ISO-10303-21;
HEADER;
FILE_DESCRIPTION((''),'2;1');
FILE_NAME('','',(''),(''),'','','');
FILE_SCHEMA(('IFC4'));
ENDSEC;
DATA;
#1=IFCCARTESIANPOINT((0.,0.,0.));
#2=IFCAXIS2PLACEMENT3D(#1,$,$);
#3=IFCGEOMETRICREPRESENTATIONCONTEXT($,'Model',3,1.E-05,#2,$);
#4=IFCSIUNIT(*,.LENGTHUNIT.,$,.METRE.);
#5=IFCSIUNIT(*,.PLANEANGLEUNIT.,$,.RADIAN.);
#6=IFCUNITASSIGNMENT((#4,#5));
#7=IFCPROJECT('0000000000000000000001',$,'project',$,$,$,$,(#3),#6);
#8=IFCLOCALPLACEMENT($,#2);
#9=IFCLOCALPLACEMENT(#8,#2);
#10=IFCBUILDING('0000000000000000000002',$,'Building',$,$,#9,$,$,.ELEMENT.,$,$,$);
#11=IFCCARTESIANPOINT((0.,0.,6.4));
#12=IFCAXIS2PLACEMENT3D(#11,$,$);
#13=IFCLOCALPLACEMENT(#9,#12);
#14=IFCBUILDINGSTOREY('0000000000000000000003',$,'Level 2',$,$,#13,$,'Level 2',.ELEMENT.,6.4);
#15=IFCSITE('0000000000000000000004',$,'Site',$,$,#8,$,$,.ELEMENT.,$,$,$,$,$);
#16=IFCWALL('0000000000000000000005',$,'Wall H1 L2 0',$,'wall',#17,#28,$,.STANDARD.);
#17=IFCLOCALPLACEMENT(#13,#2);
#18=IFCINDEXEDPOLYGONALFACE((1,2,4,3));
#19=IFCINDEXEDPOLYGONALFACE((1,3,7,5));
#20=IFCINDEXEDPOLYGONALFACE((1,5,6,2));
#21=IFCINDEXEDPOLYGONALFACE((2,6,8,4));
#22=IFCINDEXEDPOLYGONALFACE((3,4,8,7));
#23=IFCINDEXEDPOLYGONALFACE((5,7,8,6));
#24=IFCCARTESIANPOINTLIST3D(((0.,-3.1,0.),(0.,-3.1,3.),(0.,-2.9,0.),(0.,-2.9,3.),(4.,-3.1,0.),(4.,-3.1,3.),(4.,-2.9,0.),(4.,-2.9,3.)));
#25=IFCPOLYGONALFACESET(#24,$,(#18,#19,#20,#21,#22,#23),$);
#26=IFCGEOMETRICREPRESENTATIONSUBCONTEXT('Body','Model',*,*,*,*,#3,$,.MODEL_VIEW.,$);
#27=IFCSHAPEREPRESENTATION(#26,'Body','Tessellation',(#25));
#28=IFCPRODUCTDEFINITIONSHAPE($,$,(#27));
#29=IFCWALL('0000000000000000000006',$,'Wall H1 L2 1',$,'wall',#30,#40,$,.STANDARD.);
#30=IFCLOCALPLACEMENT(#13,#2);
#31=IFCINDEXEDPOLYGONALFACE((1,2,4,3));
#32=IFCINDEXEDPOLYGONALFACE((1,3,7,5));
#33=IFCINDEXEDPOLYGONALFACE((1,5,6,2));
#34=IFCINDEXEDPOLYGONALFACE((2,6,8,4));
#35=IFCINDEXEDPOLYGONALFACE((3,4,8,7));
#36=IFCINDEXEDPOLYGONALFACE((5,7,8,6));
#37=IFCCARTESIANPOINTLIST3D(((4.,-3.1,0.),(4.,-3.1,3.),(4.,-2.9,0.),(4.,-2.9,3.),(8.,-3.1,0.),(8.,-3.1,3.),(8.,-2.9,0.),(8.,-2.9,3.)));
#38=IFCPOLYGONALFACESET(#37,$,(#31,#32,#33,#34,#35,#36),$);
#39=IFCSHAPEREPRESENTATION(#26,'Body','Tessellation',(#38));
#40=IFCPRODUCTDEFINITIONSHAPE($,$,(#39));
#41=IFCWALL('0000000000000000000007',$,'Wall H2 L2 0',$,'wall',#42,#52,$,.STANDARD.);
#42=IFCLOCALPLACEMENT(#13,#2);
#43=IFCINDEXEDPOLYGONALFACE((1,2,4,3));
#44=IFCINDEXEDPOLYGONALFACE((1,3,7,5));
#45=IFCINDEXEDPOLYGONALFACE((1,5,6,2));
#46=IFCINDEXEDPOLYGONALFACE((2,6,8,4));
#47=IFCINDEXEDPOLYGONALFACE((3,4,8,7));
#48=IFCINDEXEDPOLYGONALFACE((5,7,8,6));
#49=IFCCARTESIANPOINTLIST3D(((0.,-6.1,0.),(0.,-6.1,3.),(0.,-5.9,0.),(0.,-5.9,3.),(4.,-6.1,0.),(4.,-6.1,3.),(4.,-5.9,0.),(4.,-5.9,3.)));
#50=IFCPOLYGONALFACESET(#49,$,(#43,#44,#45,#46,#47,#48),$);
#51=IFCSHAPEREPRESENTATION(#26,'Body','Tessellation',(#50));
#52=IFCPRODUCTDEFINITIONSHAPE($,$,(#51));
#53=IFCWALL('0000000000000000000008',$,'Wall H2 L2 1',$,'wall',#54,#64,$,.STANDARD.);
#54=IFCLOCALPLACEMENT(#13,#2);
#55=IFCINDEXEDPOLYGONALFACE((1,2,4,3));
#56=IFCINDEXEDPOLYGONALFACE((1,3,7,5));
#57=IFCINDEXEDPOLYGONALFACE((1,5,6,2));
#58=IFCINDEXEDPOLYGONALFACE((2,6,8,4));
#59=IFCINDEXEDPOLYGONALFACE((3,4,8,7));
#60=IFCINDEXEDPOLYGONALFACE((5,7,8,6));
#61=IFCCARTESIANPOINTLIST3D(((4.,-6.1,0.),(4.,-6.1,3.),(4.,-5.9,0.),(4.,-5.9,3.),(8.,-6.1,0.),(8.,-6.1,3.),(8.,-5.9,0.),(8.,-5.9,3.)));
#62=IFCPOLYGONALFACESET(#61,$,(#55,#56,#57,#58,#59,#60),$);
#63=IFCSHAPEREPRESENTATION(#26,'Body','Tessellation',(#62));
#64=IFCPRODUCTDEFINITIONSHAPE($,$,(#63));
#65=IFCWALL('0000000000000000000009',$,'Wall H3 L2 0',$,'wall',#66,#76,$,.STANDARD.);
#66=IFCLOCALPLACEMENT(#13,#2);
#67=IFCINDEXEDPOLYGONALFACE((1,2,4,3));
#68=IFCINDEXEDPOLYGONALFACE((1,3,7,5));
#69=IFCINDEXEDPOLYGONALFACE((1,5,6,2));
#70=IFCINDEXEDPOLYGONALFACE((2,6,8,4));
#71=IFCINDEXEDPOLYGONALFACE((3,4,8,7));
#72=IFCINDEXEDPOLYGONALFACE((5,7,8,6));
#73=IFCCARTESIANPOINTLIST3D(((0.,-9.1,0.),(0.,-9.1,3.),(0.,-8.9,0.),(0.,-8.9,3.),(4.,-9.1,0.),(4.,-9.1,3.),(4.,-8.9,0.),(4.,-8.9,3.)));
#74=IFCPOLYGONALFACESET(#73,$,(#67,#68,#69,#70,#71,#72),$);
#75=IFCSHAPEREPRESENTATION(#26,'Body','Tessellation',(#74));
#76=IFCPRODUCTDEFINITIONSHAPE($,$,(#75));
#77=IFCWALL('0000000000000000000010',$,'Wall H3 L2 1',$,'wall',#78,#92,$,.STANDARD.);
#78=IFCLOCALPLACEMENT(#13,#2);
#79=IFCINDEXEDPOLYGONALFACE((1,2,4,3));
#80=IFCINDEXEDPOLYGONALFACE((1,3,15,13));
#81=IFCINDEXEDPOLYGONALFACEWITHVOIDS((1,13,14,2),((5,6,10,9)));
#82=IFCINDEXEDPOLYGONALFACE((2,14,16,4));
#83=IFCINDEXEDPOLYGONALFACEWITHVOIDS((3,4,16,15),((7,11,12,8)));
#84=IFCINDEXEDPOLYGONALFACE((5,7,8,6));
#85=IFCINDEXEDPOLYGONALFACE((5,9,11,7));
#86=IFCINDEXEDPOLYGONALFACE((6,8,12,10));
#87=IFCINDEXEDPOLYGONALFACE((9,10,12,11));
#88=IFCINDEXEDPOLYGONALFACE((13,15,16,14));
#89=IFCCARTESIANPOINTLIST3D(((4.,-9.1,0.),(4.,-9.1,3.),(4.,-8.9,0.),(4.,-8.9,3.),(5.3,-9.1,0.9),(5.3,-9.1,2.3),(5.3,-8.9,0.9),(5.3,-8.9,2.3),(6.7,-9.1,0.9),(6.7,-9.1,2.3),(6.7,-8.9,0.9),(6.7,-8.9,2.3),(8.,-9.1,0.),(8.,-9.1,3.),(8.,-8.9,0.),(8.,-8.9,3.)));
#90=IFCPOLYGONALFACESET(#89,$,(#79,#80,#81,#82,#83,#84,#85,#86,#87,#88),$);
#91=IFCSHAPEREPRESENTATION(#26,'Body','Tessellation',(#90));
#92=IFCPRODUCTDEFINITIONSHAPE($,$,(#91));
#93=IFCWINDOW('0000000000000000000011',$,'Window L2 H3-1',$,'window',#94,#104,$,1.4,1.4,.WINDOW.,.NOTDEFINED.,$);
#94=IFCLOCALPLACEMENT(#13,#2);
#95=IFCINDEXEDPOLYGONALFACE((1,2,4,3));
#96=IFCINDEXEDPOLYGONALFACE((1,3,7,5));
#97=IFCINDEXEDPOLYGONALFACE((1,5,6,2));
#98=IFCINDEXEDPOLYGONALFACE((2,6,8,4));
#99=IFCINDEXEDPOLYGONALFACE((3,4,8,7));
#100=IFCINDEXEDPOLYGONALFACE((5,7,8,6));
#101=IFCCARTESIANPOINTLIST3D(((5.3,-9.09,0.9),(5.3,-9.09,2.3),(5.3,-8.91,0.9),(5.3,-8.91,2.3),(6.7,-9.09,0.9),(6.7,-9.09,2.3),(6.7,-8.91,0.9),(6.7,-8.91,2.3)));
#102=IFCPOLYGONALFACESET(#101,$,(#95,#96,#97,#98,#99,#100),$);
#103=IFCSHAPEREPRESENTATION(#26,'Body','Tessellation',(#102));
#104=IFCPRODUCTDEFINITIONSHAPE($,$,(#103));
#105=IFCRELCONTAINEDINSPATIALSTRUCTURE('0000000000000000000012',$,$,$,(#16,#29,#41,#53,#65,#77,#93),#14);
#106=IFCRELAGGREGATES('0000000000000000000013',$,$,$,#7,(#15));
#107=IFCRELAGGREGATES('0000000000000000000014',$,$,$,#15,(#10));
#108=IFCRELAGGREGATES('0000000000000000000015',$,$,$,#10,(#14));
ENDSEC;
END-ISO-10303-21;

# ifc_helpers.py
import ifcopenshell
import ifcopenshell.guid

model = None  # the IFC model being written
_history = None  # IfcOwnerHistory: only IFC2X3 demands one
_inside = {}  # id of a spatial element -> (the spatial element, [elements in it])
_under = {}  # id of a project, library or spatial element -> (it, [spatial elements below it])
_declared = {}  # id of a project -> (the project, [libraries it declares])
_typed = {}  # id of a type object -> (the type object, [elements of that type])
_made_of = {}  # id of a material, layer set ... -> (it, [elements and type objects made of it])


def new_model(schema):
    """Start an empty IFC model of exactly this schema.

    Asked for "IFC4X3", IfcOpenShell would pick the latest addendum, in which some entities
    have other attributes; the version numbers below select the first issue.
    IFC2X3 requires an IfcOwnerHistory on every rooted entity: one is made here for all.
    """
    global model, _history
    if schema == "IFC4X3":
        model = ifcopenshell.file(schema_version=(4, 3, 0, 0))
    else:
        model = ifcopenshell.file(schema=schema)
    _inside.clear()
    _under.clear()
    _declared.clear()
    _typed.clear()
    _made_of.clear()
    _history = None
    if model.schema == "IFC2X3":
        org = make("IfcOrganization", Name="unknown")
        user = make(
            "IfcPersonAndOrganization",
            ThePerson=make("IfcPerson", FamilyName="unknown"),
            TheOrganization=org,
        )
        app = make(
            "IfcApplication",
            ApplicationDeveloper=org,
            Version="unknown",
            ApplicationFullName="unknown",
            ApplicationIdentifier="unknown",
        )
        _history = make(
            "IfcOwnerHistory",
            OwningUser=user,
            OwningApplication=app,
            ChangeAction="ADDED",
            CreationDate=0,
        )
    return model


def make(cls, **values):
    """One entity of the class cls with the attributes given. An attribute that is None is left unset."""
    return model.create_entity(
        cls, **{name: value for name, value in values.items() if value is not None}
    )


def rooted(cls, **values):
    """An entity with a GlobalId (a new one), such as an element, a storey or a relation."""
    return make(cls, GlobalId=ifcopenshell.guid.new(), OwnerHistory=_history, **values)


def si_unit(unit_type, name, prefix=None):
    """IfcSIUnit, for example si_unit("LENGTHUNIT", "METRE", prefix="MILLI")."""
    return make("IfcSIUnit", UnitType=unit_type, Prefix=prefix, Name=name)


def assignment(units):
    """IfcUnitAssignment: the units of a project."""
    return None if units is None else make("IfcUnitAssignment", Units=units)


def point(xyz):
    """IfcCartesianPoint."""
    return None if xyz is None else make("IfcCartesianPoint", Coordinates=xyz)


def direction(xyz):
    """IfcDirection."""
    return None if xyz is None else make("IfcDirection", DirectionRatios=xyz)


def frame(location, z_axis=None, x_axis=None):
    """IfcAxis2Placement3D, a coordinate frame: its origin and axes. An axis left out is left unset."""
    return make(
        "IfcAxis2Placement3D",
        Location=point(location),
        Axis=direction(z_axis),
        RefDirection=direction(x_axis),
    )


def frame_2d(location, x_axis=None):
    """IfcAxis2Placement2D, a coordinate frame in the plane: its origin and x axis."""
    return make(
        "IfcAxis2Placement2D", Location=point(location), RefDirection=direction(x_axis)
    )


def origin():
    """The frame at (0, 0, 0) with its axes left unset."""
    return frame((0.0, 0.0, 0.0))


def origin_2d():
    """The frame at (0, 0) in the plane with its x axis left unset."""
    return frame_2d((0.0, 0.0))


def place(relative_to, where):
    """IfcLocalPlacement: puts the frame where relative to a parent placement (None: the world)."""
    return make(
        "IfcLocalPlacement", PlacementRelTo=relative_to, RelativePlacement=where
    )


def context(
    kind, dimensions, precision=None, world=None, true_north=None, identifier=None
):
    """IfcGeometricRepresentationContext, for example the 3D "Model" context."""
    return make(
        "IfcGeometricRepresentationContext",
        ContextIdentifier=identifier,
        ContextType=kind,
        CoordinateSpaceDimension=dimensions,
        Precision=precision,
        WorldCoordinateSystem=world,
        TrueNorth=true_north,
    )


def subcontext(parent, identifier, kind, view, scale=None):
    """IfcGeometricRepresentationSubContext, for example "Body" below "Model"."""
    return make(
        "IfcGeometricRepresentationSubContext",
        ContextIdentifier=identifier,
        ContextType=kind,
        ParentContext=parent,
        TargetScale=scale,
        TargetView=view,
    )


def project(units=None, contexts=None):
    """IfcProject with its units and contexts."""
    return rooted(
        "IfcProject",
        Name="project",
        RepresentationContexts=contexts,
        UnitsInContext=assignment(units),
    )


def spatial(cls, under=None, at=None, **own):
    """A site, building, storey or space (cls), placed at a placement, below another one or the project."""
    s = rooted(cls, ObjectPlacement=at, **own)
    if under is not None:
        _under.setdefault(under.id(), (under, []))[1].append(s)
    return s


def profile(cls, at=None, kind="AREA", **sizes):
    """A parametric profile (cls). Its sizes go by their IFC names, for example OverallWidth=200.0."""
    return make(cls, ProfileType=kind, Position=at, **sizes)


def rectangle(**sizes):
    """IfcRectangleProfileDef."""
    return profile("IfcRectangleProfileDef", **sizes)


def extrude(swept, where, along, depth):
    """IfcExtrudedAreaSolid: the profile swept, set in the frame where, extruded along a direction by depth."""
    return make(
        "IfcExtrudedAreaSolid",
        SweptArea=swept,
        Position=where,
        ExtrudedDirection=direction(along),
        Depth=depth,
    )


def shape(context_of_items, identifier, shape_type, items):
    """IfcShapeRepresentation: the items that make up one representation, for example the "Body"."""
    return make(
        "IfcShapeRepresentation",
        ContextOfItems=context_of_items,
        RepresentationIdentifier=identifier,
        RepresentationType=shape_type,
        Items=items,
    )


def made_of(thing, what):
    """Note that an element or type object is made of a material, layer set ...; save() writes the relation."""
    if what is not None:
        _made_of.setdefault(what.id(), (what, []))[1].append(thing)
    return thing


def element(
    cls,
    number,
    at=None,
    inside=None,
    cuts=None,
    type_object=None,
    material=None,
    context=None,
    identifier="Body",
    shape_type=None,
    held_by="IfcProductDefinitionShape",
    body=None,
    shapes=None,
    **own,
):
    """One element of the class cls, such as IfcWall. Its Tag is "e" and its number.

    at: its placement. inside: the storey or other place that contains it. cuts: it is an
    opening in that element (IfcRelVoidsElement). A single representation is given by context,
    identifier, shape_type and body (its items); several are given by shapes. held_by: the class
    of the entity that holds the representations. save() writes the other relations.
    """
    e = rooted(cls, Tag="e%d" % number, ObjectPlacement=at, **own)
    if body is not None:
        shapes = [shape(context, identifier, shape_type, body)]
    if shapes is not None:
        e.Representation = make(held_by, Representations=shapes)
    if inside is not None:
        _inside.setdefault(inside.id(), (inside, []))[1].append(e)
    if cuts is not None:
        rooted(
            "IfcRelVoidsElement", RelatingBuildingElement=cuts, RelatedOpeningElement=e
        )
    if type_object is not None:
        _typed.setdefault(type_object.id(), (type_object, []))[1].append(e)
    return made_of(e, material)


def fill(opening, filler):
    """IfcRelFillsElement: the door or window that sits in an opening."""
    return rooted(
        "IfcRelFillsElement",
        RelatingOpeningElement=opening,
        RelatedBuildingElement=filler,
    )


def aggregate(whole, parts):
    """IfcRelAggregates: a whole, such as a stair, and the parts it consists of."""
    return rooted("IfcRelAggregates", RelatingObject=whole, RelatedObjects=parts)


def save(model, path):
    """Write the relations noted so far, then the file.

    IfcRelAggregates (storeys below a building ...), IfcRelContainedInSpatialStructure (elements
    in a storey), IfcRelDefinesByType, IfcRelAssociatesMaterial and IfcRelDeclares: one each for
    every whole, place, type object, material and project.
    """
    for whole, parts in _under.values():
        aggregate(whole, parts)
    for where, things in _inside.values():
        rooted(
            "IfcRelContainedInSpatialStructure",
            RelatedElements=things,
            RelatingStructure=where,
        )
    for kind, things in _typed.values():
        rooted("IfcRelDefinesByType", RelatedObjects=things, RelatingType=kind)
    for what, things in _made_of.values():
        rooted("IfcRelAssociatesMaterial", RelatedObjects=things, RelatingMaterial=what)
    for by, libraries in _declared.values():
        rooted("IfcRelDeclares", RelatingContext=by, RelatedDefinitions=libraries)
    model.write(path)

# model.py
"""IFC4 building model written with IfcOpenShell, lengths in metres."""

from ifc_helpers import new_model, si_unit, frame, frame_2d, origin, origin_2d, place, context, subcontext, project, spatial, rectangle, extrude, element, fill, save


model = new_model("IFC4")

# Units and contexts
model_context = context("Model", 3, precision=1e-05, world=origin())
body_context = subcontext(model_context, "Body", "Model", "MODEL_VIEW")
ifc_project = project(units=[si_unit("LENGTHUNIT", "METRE"), si_unit("PLANEANGLEUNIT", "RADIAN")], contexts=[model_context])

# Site, building, storey
site_placement = place(None, origin())
site = spatial("IfcSite", under=ifc_project, at=site_placement, Name="Site", CompositionType="ELEMENT")
building_placement = place(site_placement, origin())
building = spatial("IfcBuilding", under=site, at=building_placement, Name="Building", CompositionType="ELEMENT")
storey_placement = place(building_placement, frame((0.0, 0.0, 6.4)))
storey = spatial("IfcBuildingStorey", under=building, at=storey_placement, Name="Level 2", LongName="Level 2", CompositionType="ELEMENT", Elevation=6.4)

# Walls
for number, where, z_axis, x_axis, name in (
    (1, (0.0, -3.0, 0.0), (0.0, 0.0, 1.0), (1.0, 0.0, 0.0), "Wall H1 L2 0"),
    (2, (4.0, -3.0, 0.0), (0.0, 0.0, 1.0), (1.0, 0.0, 0.0), "Wall H1 L2 1"),
    (3, (0.0, -6.0, 0.0), (0.0, 0.0, 1.0), (1.0, 0.0, 0.0), "Wall H2 L2 0"),
    (4, (4.0, -6.0, 0.0), (0.0, 0.0, 1.0), (1.0, 0.0, 0.0), "Wall H2 L2 1"),
    (5, (0.0, -9.0, 0.0), (0.0, 0.0, 1.0), (1.0, 0.0, 0.0), "Wall H3 L2 0"),
):
    element("IfcWall", number, at=place(storey_placement, frame(where, z_axis=z_axis, x_axis=x_axis)), inside=storey, Name=name, ObjectType="wall", PredefinedType="STANDARD", context=body_context, shape_type="SweptSolid", body=[
        extrude(rectangle(XDim=4.0, YDim=0.2, at=frame_2d((2.0, 0.0))), origin(), (0.0, 0.0, 1.0), 3.0),
    ])

# Wall, opening, window
wall_1_placement = place(storey_placement, frame((4.0, -9.0, 0.0), z_axis=(0.0, 0.0, 1.0), x_axis=(1.0, 0.0, 0.0)))
wall_1 = element("IfcWall", 6, at=wall_1_placement, inside=storey, Name="Wall H3 L2 1", ObjectType="wall", PredefinedType="STANDARD", context=body_context, shape_type="SweptSolid", body=[
    extrude(rectangle(XDim=4.0, YDim=0.2, at=frame_2d((2.0, 0.0))), origin(), (0.0, 0.0, 1.0), 3.0),
])
opening_1_placement = place(storey_placement, frame((6.0, -9.0, 0.9), z_axis=(0.0, 0.0, 1.0), x_axis=(1.0, 0.0, 0.0)))
opening_1 = element("IfcOpeningElement", 7, at=opening_1_placement, cuts=wall_1, ObjectType="Opening", PredefinedType="OPENING", context=body_context, shape_type="SweptSolid", body=[
    extrude(rectangle(XDim=1.4, YDim=0.22, at=origin_2d()), origin(), (0.0, 0.0, 1.0), 1.4),
])
window_1_placement = place(storey_placement, frame((6.0, -9.0, 0.9), z_axis=(0.0, 0.0, 1.0), x_axis=(1.0, 0.0, 0.0)))
window_1 = element("IfcWindow", 8, at=window_1_placement, inside=storey, Name="Window L2 H3-1", ObjectType="window", OverallHeight=1.4, OverallWidth=1.4, PartitioningType="NOTDEFINED", PredefinedType="WINDOW", context=body_context, shape_type="SweptSolid", body=[
    extrude(rectangle(XDim=1.4, YDim=0.18, at=origin_2d()), origin(), (0.0, 0.0, 1.0), 1.4),
])
fill(opening_1, window_1)

save(model, "model.ifc")
